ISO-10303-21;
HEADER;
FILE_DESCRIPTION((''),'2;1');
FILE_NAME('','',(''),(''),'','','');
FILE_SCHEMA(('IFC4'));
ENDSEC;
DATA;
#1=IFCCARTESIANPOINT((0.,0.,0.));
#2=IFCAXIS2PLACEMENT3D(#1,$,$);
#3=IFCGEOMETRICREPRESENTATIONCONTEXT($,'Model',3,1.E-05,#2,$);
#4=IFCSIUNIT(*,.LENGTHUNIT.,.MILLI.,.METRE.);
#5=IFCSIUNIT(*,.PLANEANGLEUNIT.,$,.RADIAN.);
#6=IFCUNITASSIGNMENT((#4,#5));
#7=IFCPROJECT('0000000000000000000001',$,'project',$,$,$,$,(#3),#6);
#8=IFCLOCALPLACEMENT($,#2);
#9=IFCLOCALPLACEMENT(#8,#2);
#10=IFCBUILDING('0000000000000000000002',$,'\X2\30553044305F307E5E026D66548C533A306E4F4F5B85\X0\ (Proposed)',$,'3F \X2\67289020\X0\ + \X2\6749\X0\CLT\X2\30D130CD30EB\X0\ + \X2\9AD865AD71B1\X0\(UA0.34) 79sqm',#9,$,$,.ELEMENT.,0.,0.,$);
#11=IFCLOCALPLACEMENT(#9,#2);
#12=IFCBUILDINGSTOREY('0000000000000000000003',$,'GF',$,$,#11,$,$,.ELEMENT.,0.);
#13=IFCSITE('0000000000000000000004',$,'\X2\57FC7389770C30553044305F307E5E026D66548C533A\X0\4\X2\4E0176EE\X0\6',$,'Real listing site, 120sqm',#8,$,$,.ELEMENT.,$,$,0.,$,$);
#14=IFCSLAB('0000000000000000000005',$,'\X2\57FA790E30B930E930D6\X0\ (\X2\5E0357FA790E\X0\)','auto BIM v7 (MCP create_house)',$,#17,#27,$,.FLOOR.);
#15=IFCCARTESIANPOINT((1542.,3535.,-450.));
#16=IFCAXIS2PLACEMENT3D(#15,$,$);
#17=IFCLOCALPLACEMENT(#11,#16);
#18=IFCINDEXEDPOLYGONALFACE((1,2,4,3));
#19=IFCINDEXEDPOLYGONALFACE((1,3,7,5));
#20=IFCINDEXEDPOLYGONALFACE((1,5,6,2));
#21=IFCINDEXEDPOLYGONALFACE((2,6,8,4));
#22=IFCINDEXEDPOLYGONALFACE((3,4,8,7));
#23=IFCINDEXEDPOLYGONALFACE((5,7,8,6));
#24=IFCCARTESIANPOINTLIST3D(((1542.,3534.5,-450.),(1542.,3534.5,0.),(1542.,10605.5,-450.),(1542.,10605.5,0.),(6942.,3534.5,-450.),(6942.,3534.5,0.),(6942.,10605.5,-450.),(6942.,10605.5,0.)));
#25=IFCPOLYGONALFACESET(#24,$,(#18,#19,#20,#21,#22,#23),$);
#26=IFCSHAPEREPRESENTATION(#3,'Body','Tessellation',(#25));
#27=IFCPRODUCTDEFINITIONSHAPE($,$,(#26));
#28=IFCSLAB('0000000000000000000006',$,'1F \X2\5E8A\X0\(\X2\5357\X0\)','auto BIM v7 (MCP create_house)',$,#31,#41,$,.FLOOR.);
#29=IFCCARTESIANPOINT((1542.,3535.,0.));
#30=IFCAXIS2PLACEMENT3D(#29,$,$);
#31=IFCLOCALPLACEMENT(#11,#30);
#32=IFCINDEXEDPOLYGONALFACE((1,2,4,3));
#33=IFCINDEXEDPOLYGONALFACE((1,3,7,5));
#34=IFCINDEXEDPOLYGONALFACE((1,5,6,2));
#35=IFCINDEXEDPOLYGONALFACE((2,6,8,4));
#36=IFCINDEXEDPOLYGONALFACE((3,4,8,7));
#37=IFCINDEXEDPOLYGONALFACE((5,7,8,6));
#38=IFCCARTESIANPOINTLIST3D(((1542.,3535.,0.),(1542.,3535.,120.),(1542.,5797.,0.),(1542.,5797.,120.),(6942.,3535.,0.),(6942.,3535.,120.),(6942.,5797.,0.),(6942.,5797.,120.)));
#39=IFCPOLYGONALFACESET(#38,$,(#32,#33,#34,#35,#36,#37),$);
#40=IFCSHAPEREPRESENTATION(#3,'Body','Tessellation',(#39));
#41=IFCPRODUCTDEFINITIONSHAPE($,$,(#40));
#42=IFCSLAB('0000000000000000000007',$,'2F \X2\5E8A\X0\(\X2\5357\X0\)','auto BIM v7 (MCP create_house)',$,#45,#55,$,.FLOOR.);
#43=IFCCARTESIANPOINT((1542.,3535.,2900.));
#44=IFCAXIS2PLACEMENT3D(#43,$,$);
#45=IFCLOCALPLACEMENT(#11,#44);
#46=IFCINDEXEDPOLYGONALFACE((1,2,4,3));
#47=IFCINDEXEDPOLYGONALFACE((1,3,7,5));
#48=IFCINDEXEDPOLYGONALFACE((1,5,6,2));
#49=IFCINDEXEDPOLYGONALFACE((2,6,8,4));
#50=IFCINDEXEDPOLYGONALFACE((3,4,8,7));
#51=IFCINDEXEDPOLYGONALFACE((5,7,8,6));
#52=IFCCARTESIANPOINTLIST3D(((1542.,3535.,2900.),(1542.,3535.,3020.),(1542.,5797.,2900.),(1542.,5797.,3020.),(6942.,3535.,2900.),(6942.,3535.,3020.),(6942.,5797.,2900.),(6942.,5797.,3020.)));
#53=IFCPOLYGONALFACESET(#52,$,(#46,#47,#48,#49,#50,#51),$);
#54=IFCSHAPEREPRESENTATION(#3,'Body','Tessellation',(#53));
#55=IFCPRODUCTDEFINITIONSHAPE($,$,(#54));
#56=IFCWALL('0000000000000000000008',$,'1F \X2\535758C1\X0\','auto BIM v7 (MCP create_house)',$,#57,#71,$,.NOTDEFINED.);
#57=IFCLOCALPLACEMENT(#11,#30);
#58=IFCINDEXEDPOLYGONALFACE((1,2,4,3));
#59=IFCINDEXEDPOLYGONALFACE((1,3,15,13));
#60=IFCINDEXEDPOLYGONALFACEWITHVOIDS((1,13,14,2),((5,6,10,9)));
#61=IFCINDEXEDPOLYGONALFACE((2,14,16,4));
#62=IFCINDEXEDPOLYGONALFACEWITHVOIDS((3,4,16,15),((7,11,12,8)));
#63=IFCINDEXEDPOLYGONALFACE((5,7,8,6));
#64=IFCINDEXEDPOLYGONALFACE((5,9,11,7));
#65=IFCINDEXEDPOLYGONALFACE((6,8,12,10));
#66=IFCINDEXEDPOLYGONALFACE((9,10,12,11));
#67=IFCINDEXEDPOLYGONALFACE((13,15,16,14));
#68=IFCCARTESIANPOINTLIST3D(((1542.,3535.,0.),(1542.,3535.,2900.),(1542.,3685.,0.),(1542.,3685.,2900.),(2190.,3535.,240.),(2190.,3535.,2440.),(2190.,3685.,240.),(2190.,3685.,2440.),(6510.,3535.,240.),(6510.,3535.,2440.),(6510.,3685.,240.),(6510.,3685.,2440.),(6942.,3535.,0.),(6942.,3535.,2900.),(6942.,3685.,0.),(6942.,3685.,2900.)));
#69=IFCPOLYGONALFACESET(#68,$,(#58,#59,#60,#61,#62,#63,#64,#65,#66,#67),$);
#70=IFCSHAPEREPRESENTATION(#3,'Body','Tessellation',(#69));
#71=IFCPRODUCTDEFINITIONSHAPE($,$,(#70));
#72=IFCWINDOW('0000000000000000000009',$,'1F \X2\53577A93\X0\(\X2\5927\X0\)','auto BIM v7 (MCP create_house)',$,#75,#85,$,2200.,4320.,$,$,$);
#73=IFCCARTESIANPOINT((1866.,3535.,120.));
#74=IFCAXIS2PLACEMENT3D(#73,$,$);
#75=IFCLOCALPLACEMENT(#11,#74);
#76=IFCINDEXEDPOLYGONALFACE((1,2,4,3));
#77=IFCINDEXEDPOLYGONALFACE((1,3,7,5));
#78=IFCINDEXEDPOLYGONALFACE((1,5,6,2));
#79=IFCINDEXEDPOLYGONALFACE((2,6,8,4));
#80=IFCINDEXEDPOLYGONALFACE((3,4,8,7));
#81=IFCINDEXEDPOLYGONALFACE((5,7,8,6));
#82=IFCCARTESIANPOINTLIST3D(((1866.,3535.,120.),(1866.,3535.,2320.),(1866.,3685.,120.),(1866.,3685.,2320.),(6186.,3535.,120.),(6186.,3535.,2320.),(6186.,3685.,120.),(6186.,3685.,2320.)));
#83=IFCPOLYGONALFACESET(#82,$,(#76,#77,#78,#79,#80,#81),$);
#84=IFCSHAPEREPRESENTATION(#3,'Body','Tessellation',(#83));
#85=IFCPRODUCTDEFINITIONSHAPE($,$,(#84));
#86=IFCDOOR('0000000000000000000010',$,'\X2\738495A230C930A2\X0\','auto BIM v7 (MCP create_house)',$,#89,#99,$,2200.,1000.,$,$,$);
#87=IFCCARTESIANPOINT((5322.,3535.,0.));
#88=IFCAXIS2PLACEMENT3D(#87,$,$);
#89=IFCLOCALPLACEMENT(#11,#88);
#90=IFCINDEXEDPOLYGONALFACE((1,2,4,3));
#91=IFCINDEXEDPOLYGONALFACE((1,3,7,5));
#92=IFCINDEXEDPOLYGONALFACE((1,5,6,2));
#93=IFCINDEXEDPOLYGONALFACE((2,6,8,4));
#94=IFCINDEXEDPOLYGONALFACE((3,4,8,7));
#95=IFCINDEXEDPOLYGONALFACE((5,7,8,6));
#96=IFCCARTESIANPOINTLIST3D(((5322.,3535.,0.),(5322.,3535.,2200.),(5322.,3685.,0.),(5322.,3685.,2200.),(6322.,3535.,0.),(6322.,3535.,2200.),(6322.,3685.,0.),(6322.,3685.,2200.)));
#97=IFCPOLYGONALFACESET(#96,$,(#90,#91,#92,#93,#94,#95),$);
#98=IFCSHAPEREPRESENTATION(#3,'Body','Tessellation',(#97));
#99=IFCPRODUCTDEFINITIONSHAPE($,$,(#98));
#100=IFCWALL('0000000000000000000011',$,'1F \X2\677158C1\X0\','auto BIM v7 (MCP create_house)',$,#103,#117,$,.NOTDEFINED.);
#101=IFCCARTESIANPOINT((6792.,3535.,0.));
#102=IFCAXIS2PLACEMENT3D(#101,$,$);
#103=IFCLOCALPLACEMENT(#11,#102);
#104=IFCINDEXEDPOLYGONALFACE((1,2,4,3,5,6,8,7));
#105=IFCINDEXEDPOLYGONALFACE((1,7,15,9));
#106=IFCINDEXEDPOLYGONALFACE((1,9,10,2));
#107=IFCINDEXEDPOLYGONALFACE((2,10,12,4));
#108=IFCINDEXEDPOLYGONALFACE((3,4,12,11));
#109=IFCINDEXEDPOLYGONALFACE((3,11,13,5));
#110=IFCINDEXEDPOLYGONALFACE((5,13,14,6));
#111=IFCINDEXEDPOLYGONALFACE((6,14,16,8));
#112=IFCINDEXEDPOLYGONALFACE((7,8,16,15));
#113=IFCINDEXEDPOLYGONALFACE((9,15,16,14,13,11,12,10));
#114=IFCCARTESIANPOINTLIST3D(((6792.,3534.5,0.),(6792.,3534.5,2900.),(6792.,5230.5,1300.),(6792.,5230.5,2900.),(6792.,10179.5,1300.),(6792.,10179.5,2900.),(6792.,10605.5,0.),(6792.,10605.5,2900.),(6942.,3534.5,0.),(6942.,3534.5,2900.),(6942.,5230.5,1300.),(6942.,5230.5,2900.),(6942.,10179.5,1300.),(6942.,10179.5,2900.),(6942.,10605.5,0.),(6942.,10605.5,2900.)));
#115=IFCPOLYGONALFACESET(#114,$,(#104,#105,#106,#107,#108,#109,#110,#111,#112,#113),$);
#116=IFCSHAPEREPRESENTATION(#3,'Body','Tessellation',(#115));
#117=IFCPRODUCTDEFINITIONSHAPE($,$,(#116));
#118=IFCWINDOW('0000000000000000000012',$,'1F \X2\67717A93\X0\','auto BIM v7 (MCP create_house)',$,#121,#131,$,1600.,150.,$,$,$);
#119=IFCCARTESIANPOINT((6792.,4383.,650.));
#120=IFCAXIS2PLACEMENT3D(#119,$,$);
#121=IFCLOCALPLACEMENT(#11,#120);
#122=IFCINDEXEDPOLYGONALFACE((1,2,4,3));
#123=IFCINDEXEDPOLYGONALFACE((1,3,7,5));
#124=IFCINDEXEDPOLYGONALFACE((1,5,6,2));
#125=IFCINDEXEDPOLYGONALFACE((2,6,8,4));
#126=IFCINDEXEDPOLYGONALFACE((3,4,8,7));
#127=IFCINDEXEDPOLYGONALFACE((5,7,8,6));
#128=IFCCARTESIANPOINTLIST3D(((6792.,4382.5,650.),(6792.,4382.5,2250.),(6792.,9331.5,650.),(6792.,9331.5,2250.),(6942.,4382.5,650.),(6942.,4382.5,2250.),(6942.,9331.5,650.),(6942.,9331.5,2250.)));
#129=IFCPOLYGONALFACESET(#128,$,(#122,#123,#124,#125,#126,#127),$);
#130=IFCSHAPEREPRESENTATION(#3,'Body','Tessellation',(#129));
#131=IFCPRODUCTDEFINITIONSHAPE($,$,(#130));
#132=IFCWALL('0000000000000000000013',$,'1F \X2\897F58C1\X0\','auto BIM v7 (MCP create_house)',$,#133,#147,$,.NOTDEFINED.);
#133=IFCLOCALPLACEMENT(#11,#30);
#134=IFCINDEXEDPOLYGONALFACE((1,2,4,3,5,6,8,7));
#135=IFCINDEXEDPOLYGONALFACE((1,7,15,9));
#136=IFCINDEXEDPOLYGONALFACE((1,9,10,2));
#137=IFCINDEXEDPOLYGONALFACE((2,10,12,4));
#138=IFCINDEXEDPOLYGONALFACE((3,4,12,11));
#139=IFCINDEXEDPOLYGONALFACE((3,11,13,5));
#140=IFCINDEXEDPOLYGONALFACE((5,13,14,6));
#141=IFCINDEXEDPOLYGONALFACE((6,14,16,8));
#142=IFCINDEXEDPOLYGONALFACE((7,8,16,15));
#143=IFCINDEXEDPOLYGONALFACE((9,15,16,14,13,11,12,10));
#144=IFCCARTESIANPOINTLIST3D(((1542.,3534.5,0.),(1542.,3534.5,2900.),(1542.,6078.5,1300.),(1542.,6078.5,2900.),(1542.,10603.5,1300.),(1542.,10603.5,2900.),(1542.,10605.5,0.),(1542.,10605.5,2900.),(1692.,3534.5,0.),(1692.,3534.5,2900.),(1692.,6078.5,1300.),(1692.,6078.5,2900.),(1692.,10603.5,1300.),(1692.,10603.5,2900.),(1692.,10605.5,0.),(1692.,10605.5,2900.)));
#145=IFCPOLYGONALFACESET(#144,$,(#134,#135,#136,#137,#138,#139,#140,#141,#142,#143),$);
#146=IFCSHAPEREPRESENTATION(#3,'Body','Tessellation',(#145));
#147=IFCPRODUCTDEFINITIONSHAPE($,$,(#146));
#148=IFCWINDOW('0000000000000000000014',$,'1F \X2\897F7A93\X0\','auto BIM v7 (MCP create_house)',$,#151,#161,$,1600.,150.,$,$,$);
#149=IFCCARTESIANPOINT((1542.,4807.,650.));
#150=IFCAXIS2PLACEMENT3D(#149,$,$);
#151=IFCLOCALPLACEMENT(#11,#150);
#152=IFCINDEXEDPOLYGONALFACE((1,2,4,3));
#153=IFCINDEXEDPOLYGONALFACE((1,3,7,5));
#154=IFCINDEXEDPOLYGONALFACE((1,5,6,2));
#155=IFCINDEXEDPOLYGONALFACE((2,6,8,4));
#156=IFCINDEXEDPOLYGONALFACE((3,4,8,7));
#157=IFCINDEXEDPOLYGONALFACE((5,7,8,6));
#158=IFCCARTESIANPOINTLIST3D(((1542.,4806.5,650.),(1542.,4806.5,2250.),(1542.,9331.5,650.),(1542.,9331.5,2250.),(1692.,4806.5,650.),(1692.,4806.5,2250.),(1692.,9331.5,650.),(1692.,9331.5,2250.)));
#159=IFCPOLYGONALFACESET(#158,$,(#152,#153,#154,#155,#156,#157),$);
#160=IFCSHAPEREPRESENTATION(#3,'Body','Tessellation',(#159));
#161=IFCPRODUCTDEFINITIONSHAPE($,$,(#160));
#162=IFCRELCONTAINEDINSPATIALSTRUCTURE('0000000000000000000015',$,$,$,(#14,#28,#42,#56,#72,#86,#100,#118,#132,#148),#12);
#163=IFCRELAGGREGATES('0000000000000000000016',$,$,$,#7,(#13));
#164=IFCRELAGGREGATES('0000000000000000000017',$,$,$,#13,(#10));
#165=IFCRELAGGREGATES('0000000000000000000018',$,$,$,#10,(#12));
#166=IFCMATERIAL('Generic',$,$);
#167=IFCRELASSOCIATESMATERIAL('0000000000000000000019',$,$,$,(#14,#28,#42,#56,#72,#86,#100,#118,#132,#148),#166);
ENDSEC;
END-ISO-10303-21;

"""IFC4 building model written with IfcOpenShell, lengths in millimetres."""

from ifc_helpers import new_model, si_unit, frame, frame_2d, origin, place, context, project, spatial, rectangle, extrude, material, element, fill, save


model = new_model("IFC4")

# Units and contexts
model_context = context("Model", 3, precision=1e-05, world=origin())
ifc_project = project(units=[si_unit("LENGTHUNIT", "METRE", prefix="MILLI"), si_unit("PLANEANGLEUNIT", "RADIAN")], contexts=[model_context])

# Site, building, storey
site_placement = place(None, origin())
site = spatial("IfcSite", under=ifc_project, at=site_placement, Name="埼玉県さいたま市浦和区4丁目6", ObjectType="Real listing site, 120sqm", CompositionType="ELEMENT", RefElevation=0.0)
building_placement = place(site_placement, origin())
building = spatial("IfcBuilding", under=site, at=building_placement, Name="さいたま市浦和区の住宅 (Proposed)", ObjectType="3F 木造 + 杉CLTパネル + 高断熱(UA0.34) 79sqm", CompositionType="ELEMENT", ElevationOfRefHeight=0.0, ElevationOfTerrain=0.0)
storey_placement = place(building_placement, origin())
storey = spatial("IfcBuildingStorey", under=building, at=storey_placement, Name="GF", CompositionType="ELEMENT", Elevation=0.0)

# Slabs
ifc_material = material(Name="Generic")
slab_1_placement = place(storey_placement, frame((1542.0, 3535.0, -450.0)))
element("IfcSlab", 1, at=slab_1_placement, inside=storey, material=ifc_material, Name="基礎スラブ (布基礎)", Description="auto BIM v7 (MCP create_house)", PredefinedType="FLOOR", context=model_context, shape_type="SweptSolid", body=[
    extrude(rectangle(XDim=5400.0, YDim=7071.0, at=frame_2d((2700.0, 3535.0))), frame((1542.0, 3535.0, -450.0)), (0.0, 0.0, 1.0), 450.0),
])
slab_2_placement = place(storey_placement, frame((1542.0, 3535.0, 0.0)))
element("IfcSlab", 2, at=slab_2_placement, inside=storey, material=ifc_material, Name="1F 床(南)", Description="auto BIM v7 (MCP create_house)", PredefinedType="FLOOR", context=model_context, shape_type="SweptSolid", body=[
    extrude(rectangle(XDim=5400.0, YDim=2262.0, at=frame_2d((2700.0, 1131.0))), frame((1542.0, 3535.0, 0.0)), (0.0, 0.0, 1.0), 120.0),
])
slab_3_placement = place(storey_placement, frame((1542.0, 3535.0, 2900.0)))
element("IfcSlab", 3, at=slab_3_placement, inside=storey, material=ifc_material, Name="2F 床(南)", Description="auto BIM v7 (MCP create_house)", PredefinedType="FLOOR", context=model_context, shape_type="SweptSolid", body=[
    extrude(rectangle(XDim=5400.0, YDim=2262.0, at=frame_2d((2700.0, 1131.0))), frame((1542.0, 3535.0, 2900.0)), (0.0, 0.0, 1.0), 120.0),
])

# Wall, openings, window, door
wall_1_placement = place(storey_placement, frame((1542.0, 3535.0, 0.0)))
wall_1 = element("IfcWall", 4, at=wall_1_placement, inside=storey, material=ifc_material, Name="1F 南壁", Description="auto BIM v7 (MCP create_house)", PredefinedType="NOTDEFINED", context=model_context, shape_type="SweptSolid", body=[
    extrude(rectangle(XDim=5400.0, YDim=150.0, at=frame_2d((2700.0, 75.0))), frame((1542.0, 3535.0, 0.0)), (0.0, 0.0, 1.0), 2900.0),
])
opening_1_placement = place(storey_placement, frame((1866.0, 3535.0, 120.0)))
opening_1 = element("IfcOpeningElement", 5, at=opening_1_placement, cuts=wall_1, PredefinedType="NOTDEFINED", context=model_context, shape_type="SweptSolid", body=[
    extrude(rectangle(XDim=4320.0, YDim=150.0, at=frame_2d((2160.0, 75.0))), frame((1866.0, 3535.0, 120.0)), (0.0, 0.0, 1.0), 2200.0),
])
opening_2_placement = place(storey_placement, frame((5322.0, 3535.0, 0.0)))
opening_2 = element("IfcOpeningElement", 6, at=opening_2_placement, cuts=wall_1, PredefinedType="NOTDEFINED", context=model_context, shape_type="SweptSolid", body=[
    extrude(rectangle(XDim=1000.0, YDim=150.0, at=frame_2d((500.0, 75.0))), frame((5322.0, 3535.0, 0.0)), (0.0, 0.0, 1.0), 2200.0),
])
window_1_placement = place(storey_placement, frame((1866.0, 3535.0, 120.0)))
window_1 = element("IfcWindow", 7, at=window_1_placement, inside=storey, material=ifc_material, Name="1F 南窓(大)", Description="auto BIM v7 (MCP create_house)", OverallHeight=2200.0, OverallWidth=4320.0, context=model_context, shape_type="SweptSolid", body=[
    extrude(rectangle(XDim=4320.0, YDim=150.0, at=frame_2d((2160.0, 75.0))), frame((1866.0, 3535.0, 120.0)), (0.0, 0.0, 1.0), 2200.0),
])
fill(opening_1, window_1)
door_placement = place(storey_placement, frame((5322.0, 3535.0, 0.0)))
door = element("IfcDoor", 8, at=door_placement, inside=storey, material=ifc_material, Name="玄関ドア", Description="auto BIM v7 (MCP create_house)", OverallHeight=2200.0, OverallWidth=1000.0, context=model_context, shape_type="SweptSolid", body=[
    extrude(rectangle(XDim=1000.0, YDim=150.0, at=frame_2d((500.0, 75.0))), frame((5322.0, 3535.0, 0.0)), (0.0, 0.0, 1.0), 2200.0),
])
fill(opening_2, door)

# Walls, openings, windows
wall_2_placement = place(storey_placement, frame((6792.0, 3535.0, 0.0)))
wall_2 = element("IfcWall", 9, at=wall_2_placement, inside=storey, material=ifc_material, Name="1F 東壁", Description="auto BIM v7 (MCP create_house)", PredefinedType="NOTDEFINED", context=model_context, shape_type="SweptSolid", body=[
    extrude(rectangle(XDim=150.0, YDim=7071.0, at=frame_2d((75.0, 3535.0))), frame((6792.0, 3535.0, 0.0)), (0.0, 0.0, 1.0), 2900.0),
])
opening_3_placement = place(storey_placement, frame((6792.0, 4383.0, 650.0)))
opening_3 = element("IfcOpeningElement", 10, at=opening_3_placement, cuts=wall_2, PredefinedType="NOTDEFINED", context=model_context, shape_type="SweptSolid", body=[
    extrude(rectangle(XDim=150.0, YDim=4949.0, at=frame_2d((75.0, 2474.0))), frame((6792.0, 4383.0, 650.0)), (0.0, 0.0, 1.0), 1600.0),
])
window_2_placement = place(storey_placement, frame((6792.0, 4383.0, 650.0)))
window_2 = element("IfcWindow", 11, at=window_2_placement, inside=storey, material=ifc_material, Name="1F 東窓", Description="auto BIM v7 (MCP create_house)", OverallHeight=1600.0, OverallWidth=150.0, context=model_context, shape_type="SweptSolid", body=[
    extrude(rectangle(XDim=150.0, YDim=4949.0, at=frame_2d((75.0, 2474.0))), frame((6792.0, 4383.0, 650.0)), (0.0, 0.0, 1.0), 1600.0),
])
fill(opening_3, window_2)
wall_3_placement = place(storey_placement, frame((1542.0, 3535.0, 0.0)))
wall_3 = element("IfcWall", 12, at=wall_3_placement, inside=storey, material=ifc_material, Name="1F 西壁", Description="auto BIM v7 (MCP create_house)", PredefinedType="NOTDEFINED", context=model_context, shape_type="SweptSolid", body=[
    extrude(rectangle(XDim=150.0, YDim=7071.0, at=frame_2d((75.0, 3535.0))), frame((1542.0, 3535.0, 0.0)), (0.0, 0.0, 1.0), 2900.0),
])
opening_4_placement = place(storey_placement, frame((1542.0, 4807.0, 650.0)))
opening_4 = element("IfcOpeningElement", 13, at=opening_4_placement, cuts=wall_3, PredefinedType="NOTDEFINED", context=model_context, shape_type="SweptSolid", body=[
    extrude(rectangle(XDim=150.0, YDim=4525.0, at=frame_2d((75.0, 2262.0))), frame((1542.0, 4807.0, 650.0)), (0.0, 0.0, 1.0), 1600.0),
])
window_3_placement = place(storey_placement, frame((1542.0, 4807.0, 650.0)))
window_3 = element("IfcWindow", 14, at=window_3_placement, inside=storey, material=ifc_material, Name="1F 西窓", Description="auto BIM v7 (MCP create_house)", OverallHeight=1600.0, OverallWidth=150.0, context=model_context, shape_type="SweptSolid", body=[
    extrude(rectangle(XDim=150.0, YDim=4525.0, at=frame_2d((75.0, 2262.0))), frame((1542.0, 4807.0, 650.0)), (0.0, 0.0, 1.0), 1600.0),
])
fill(opening_4, window_3)

save(model, "model.ifc")
